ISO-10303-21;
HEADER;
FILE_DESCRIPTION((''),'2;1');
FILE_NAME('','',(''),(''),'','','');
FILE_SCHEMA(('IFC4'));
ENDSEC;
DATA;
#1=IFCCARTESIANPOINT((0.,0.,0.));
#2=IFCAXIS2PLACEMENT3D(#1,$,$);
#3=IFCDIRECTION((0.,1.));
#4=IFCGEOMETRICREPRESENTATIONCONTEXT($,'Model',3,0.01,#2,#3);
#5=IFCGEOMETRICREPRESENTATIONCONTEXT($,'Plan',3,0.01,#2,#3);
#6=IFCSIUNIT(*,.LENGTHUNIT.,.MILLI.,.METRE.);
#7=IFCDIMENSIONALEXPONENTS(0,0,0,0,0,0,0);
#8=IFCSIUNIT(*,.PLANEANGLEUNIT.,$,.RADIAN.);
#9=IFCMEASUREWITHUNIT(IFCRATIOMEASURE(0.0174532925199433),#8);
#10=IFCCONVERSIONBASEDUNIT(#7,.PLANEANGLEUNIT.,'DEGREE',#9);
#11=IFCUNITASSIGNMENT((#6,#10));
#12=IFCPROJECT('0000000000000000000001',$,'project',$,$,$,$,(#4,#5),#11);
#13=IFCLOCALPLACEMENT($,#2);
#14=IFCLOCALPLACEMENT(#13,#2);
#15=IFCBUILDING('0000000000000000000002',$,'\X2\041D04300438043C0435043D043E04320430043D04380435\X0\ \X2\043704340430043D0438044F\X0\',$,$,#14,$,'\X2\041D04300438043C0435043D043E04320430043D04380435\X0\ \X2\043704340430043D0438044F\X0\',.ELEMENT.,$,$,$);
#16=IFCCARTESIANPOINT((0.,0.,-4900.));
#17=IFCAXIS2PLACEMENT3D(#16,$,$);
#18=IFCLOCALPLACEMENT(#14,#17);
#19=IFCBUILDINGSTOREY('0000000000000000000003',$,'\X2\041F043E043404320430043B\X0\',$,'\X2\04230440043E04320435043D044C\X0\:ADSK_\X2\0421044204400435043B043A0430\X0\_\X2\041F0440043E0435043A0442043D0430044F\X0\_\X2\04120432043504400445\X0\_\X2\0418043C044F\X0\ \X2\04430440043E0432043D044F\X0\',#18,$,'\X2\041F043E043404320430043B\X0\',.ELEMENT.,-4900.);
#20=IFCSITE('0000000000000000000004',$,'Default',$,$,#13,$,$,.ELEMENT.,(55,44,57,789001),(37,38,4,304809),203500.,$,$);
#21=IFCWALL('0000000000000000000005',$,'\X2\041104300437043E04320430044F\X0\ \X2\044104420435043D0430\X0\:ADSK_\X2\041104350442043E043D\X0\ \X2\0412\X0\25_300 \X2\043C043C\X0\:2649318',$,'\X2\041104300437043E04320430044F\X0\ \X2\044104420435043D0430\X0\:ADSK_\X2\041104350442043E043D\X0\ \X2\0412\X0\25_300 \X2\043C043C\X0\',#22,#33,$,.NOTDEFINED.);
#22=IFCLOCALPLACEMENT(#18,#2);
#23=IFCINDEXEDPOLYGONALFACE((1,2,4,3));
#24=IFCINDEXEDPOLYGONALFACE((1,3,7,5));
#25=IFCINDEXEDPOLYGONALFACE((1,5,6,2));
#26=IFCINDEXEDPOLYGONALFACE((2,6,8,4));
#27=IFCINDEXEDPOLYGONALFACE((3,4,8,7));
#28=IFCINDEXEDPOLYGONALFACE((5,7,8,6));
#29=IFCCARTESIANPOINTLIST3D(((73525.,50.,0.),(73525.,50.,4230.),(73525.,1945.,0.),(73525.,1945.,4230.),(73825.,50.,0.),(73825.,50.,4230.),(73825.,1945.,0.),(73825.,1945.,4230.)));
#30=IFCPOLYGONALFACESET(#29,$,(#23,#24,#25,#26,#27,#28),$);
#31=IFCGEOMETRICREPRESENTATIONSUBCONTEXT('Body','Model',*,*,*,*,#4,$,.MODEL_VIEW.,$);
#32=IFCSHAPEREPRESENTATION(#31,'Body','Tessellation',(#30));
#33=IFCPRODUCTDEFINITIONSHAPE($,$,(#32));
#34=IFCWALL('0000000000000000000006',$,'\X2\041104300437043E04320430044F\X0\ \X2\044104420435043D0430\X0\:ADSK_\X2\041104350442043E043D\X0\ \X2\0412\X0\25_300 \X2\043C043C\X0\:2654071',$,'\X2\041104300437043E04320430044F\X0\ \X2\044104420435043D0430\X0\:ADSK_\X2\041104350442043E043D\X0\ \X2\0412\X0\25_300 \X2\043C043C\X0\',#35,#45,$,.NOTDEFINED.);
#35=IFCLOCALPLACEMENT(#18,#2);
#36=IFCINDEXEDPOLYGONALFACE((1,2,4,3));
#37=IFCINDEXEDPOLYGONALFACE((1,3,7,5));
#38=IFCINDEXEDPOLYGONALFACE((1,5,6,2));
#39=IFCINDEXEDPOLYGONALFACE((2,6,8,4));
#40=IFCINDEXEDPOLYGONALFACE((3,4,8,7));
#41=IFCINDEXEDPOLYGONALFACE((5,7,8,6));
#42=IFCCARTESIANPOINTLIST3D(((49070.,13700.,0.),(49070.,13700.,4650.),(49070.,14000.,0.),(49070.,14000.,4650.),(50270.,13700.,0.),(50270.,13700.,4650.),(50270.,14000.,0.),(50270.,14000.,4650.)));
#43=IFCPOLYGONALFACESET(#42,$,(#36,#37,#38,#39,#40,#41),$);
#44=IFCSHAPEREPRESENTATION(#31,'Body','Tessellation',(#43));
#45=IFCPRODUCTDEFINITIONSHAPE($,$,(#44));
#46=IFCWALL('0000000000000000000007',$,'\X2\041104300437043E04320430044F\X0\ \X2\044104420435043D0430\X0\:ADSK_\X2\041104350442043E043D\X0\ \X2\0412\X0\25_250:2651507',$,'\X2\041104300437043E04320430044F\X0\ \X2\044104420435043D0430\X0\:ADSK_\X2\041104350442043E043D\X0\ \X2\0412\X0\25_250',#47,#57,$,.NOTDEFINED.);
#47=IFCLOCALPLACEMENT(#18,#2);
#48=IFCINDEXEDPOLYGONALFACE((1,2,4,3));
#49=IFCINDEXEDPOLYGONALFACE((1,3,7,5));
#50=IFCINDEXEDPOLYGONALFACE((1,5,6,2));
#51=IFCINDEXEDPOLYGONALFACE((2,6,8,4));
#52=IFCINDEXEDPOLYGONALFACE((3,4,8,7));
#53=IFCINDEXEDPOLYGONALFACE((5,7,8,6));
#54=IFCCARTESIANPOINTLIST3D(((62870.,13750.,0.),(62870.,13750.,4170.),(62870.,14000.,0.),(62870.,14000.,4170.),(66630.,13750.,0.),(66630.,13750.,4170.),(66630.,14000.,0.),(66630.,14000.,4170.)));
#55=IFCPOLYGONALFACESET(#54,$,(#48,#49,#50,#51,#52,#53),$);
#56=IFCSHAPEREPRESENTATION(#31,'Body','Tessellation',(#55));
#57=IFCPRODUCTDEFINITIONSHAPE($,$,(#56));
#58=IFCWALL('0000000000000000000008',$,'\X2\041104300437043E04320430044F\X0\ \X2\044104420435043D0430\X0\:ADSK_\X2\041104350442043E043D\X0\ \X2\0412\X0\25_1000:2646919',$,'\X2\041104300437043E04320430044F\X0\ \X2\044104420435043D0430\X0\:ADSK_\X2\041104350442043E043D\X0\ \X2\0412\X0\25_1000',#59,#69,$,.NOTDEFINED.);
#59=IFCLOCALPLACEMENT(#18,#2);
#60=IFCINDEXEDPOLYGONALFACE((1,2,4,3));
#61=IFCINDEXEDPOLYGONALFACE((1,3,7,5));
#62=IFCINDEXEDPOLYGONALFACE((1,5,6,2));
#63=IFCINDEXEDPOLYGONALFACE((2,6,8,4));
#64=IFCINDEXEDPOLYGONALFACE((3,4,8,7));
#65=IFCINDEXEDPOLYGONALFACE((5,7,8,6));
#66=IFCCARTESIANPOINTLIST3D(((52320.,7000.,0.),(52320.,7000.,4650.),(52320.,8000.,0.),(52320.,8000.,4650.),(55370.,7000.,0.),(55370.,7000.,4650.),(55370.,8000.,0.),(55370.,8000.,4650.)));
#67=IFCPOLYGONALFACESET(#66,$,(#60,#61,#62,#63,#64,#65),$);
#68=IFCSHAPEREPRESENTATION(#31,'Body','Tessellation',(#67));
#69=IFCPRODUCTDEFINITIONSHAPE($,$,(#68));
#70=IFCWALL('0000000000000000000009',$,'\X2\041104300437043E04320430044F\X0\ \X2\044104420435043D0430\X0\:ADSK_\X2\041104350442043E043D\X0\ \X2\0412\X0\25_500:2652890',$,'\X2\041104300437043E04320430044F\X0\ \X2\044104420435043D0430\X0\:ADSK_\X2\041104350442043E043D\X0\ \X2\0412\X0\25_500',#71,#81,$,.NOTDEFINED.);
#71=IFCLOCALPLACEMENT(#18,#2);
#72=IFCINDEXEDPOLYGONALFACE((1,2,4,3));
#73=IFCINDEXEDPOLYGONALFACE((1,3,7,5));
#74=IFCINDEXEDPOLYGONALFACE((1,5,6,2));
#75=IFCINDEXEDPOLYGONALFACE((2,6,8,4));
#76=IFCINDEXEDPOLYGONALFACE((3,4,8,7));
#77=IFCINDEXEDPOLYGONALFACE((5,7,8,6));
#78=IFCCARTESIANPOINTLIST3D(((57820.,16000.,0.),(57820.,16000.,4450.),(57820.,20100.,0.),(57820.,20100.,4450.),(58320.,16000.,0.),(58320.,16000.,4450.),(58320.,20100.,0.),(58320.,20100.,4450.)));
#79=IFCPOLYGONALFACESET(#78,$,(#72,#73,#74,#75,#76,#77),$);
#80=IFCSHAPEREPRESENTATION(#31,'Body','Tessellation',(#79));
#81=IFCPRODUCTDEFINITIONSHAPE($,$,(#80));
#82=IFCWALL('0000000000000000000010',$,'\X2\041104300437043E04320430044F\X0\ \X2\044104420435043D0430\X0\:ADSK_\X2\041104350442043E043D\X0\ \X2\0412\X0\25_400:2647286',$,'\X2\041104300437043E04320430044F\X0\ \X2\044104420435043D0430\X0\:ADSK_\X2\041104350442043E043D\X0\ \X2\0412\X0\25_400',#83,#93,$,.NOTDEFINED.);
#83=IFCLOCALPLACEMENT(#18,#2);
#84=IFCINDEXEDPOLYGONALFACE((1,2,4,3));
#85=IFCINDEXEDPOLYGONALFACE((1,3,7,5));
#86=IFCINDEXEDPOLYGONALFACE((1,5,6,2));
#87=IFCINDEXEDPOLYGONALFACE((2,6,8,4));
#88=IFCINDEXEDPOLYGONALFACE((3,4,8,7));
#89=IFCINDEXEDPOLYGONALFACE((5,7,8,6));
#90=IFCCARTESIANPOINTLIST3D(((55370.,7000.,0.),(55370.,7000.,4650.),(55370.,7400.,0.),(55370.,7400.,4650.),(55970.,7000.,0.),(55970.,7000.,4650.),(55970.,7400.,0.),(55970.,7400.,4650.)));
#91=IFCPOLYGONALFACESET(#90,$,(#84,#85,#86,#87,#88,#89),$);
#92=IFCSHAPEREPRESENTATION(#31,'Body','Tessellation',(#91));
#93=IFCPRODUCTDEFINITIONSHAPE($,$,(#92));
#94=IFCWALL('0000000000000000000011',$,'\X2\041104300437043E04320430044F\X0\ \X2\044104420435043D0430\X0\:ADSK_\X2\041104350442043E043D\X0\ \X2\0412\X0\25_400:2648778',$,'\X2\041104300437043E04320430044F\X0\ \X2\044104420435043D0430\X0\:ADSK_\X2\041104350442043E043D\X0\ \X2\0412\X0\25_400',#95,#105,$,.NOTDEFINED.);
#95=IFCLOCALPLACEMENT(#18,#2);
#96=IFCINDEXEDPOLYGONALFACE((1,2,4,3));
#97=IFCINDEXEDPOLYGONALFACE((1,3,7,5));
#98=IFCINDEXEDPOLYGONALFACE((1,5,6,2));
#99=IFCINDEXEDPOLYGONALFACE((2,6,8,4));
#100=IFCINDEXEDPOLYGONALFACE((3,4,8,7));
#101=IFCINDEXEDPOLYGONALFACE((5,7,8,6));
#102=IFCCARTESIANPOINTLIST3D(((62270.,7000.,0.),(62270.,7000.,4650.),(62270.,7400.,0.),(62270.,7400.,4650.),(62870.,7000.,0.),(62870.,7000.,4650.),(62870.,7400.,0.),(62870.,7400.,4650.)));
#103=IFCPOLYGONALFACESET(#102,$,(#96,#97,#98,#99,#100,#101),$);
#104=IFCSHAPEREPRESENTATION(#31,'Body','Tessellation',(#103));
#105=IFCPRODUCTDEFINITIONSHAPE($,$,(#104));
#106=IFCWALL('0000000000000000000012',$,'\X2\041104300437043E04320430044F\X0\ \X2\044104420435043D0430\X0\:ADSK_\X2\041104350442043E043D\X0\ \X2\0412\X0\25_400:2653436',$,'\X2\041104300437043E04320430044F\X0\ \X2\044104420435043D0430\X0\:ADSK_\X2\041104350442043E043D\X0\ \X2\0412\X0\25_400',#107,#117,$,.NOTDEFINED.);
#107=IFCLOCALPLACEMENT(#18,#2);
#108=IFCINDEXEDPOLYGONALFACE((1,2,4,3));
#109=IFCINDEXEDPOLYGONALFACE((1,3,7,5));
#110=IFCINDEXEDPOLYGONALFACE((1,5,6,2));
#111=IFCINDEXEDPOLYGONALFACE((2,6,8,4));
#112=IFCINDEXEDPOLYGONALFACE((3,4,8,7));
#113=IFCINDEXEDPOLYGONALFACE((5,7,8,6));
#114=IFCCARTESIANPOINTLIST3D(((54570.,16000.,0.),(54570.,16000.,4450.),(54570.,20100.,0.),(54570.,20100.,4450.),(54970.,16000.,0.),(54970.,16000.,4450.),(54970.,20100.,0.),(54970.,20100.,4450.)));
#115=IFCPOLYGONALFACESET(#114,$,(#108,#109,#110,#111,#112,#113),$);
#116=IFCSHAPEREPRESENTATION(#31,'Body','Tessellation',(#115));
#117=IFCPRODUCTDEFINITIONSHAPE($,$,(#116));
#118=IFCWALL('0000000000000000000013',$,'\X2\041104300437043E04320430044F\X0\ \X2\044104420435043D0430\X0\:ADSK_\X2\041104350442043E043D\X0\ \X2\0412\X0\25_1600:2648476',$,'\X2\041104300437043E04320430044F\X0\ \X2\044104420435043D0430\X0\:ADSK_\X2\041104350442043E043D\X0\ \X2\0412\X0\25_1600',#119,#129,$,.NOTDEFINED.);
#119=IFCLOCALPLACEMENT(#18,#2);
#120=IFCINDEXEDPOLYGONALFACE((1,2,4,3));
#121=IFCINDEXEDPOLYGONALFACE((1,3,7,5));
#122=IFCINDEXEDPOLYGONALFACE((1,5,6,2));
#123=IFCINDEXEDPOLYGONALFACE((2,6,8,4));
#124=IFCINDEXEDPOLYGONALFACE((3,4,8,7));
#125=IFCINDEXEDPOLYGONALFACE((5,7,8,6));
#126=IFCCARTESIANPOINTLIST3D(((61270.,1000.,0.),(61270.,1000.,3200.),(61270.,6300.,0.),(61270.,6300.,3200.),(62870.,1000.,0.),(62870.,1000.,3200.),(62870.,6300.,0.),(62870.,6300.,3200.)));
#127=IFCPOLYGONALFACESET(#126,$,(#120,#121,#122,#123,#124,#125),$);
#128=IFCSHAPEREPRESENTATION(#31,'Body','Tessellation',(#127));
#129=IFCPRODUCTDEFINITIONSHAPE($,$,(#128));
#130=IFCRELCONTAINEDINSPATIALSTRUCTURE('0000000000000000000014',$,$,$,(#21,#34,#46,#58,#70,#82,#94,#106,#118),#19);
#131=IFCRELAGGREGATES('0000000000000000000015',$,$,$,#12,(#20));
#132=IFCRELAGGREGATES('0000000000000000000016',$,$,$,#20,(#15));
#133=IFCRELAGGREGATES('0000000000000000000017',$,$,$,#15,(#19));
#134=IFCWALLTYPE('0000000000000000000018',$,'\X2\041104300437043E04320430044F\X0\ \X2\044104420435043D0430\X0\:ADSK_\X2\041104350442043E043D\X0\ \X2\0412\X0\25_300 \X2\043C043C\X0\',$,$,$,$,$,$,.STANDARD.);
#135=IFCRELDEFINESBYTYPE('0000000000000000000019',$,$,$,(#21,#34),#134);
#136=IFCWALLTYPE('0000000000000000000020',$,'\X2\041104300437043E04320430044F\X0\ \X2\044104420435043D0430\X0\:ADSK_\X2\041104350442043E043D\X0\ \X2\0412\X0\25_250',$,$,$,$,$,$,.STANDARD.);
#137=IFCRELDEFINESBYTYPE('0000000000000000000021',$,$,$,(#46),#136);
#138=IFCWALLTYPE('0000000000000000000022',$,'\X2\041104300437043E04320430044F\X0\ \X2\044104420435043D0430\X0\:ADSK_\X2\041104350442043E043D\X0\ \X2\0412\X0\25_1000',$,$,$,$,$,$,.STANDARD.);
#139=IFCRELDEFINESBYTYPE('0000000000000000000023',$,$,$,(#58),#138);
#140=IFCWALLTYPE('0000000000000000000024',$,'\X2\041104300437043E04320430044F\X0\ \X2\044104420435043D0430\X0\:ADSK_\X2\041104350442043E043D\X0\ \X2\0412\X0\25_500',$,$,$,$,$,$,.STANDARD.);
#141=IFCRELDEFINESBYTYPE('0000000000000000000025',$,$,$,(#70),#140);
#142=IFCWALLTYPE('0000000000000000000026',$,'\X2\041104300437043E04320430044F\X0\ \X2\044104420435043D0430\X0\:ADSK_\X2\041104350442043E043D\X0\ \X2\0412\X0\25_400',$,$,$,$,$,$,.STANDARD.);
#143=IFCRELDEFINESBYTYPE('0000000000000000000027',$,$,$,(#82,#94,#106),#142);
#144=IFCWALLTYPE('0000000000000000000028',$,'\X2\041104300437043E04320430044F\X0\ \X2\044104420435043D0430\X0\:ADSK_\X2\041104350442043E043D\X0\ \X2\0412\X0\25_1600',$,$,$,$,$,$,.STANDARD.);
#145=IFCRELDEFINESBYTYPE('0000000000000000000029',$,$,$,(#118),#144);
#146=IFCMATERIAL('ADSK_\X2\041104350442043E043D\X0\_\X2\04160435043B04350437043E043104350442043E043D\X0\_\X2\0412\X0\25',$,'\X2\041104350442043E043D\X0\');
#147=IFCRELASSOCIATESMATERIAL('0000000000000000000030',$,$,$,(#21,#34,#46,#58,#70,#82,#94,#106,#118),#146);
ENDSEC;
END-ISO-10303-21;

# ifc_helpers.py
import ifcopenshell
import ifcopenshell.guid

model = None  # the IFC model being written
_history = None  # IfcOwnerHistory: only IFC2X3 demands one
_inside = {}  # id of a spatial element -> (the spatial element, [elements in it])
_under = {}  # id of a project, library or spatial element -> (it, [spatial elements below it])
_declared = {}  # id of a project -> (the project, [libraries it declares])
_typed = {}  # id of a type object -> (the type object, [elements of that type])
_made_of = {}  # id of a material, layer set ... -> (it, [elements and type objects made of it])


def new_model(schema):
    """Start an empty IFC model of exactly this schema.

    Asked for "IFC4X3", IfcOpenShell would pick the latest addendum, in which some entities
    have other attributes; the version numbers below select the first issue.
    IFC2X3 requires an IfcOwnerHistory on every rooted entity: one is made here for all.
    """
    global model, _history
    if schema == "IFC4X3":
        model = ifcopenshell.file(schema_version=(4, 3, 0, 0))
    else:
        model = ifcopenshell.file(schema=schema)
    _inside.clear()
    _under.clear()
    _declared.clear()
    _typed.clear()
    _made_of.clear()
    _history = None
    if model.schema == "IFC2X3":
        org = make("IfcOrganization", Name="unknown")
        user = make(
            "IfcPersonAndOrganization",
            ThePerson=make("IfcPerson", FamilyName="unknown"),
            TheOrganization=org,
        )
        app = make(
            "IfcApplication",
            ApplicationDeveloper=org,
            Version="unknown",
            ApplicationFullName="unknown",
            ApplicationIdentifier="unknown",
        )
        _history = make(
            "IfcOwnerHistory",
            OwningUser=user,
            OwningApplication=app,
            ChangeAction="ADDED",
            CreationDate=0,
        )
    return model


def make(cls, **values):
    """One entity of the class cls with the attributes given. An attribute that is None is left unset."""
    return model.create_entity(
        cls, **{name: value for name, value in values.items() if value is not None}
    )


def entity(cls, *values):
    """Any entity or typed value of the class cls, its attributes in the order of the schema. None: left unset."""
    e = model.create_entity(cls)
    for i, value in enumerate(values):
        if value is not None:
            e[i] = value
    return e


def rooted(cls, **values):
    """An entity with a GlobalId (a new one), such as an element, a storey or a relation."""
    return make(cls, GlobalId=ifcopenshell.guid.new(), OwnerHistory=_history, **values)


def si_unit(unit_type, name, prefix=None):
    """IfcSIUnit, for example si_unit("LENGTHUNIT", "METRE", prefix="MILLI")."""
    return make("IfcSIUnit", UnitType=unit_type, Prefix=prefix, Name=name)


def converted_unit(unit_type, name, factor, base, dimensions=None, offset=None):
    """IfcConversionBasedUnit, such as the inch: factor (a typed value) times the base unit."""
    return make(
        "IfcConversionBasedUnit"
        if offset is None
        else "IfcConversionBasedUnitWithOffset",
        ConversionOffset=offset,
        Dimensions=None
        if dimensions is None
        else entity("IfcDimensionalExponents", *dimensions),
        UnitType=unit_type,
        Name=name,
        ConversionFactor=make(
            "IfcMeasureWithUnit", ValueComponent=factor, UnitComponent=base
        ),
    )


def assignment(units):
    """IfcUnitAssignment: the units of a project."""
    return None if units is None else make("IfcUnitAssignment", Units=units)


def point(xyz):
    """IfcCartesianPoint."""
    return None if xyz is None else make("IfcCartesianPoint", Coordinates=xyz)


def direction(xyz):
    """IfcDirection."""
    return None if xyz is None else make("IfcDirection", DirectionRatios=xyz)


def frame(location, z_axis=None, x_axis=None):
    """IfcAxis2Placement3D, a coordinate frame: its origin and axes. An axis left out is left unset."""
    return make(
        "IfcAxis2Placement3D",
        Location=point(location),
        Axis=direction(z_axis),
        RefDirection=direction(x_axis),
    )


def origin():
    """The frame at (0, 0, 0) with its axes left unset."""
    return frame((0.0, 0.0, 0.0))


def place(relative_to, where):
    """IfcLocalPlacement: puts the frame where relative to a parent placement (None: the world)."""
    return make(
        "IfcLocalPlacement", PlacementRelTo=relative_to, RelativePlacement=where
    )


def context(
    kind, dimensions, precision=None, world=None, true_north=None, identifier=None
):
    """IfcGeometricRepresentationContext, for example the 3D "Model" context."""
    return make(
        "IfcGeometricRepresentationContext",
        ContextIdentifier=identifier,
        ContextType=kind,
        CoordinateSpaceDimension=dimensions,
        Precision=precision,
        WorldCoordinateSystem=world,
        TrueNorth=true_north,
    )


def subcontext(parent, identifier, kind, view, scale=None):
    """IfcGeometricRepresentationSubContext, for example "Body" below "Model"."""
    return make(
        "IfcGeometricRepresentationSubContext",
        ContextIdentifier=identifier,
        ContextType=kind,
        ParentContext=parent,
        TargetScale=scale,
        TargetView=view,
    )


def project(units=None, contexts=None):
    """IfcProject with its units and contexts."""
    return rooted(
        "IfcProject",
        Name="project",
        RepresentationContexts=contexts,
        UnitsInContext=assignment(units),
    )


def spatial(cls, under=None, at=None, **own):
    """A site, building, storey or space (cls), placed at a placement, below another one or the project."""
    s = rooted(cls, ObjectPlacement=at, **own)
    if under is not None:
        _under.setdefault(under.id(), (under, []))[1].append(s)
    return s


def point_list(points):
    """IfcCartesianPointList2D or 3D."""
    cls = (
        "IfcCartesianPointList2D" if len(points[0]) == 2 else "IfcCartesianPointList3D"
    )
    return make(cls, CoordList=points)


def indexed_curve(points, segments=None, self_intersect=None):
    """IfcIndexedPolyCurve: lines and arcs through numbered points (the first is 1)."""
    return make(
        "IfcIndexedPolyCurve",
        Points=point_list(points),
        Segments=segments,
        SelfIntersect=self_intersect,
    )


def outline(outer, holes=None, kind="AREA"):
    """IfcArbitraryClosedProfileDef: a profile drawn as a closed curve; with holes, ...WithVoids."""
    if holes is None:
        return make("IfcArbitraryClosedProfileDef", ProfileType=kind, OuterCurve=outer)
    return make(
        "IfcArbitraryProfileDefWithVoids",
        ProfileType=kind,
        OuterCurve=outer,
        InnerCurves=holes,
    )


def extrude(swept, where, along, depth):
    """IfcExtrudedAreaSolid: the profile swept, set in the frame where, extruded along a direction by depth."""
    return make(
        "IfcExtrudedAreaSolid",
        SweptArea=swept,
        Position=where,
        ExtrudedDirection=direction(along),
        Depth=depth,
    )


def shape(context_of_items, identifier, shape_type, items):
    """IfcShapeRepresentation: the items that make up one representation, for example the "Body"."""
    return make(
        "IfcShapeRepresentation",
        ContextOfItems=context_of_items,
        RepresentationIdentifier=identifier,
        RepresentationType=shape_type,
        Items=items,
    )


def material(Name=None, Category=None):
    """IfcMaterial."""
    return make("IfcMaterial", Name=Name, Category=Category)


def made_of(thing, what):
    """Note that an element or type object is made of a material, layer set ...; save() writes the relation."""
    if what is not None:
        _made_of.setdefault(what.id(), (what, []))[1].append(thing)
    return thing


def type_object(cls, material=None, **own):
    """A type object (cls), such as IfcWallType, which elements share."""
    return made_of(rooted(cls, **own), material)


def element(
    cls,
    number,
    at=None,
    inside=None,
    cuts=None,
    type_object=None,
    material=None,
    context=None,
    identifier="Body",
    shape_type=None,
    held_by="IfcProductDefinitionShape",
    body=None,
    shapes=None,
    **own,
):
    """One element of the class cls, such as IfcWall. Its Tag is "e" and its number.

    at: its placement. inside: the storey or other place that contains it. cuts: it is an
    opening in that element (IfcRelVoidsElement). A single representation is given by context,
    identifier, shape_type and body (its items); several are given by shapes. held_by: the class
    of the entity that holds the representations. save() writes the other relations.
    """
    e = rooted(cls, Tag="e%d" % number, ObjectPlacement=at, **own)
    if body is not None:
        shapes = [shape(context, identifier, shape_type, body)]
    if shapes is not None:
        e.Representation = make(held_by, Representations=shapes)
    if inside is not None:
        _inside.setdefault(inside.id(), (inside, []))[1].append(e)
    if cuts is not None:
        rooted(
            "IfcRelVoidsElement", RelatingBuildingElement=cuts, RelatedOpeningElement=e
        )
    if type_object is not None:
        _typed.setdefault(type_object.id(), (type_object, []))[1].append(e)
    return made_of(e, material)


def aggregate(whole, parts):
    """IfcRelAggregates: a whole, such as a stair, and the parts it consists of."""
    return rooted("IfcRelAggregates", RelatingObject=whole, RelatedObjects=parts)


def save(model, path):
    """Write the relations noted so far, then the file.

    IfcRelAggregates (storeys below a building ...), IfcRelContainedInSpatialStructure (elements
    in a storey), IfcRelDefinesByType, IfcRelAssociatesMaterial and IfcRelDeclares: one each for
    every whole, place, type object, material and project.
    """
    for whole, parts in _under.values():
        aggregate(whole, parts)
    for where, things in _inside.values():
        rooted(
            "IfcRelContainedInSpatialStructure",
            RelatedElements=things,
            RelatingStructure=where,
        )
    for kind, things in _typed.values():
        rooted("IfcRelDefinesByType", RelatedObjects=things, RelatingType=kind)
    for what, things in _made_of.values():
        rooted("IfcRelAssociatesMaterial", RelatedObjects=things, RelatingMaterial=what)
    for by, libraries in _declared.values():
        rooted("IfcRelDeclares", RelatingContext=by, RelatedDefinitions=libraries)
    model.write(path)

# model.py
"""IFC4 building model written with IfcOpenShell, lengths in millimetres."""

from ifc_helpers import new_model, entity, si_unit, converted_unit, direction, frame, origin, place, context, subcontext, project, spatial, indexed_curve, outline, extrude, material, type_object, element, save


model = new_model("IFC4")

# Units and contexts
model_context = context("Model", 3, precision=0.01, world=origin(), true_north=direction((0.0, 1.0)))
plan_context = context("Plan", 3, precision=0.01, world=origin(), true_north=direction((0.0, 1.0)))
body_context = subcontext(model_context, "Body", "Model", "MODEL_VIEW")
ifc_project = project(units=[si_unit("LENGTHUNIT", "METRE", prefix="MILLI"), converted_unit("PLANEANGLEUNIT", "DEGREE", entity("IfcRatioMeasure", 0.0174532925199433), si_unit("PLANEANGLEUNIT", "RADIAN"), dimensions=[0, 0, 0, 0, 0, 0, 0])], contexts=[model_context, plan_context])

# Site, building, storey
site_placement = place(None, origin())
site = spatial("IfcSite", under=ifc_project, at=site_placement, Name="Default", CompositionType="ELEMENT", RefLatitude=(55, 44, 57, 789001), RefLongitude=(37, 38, 4, 304809), RefElevation=203500.0)
building_placement = place(site_placement, origin())
building = spatial("IfcBuilding", under=site, at=building_placement, Name="Наименование здания", LongName="Наименование здания", CompositionType="ELEMENT")
storey_placement = place(building_placement, frame((0.0, 0.0, -4900.0)))
storey = spatial("IfcBuildingStorey", under=building, at=storey_placement, Name="Подвал", ObjectType="Уровень:ADSK_Стрелка_Проектная_Вверх_Имя уровня", LongName="Подвал", CompositionType="ELEMENT", Elevation=-4900.0)

# Shared definitions
ifc_material = material(Name="ADSK_Бетон_Железобетон_В25", Category="Бетон")

# Walls
wall_type_1 = type_object("IfcWallType", Name="Базовая стена:ADSK_Бетон В25_300 мм", PredefinedType="STANDARD")
wall_1_placement = place(storey_placement, frame((73675.0, 1945.0, 0.0), z_axis=(0.0, 0.0, 1.0), x_axis=(0.0, -1.0, 0.0)))
element("IfcWall", 1, at=wall_1_placement, inside=storey, type_object=wall_type_1, material=ifc_material, Name="Базовая стена:ADSK_Бетон В25_300 мм:2649318", ObjectType="Базовая стена:ADSK_Бетон В25_300 мм", PredefinedType="NOTDEFINED", context=body_context, shape_type="SweptSolid", body=[
    extrude(outline(indexed_curve([(1895.0, 150.0), (0.0, 150.0), (0.0, -150.0), (1895.0, -150.0), (1895.0, 150.0)], self_intersect=False)), origin(), (0.0, 0.0, 1.0), 4230.0),
])
wall_2_placement = place(storey_placement, frame((49070.0, 13850.0, 0.0)))
element("IfcWall", 2, at=wall_2_placement, inside=storey, type_object=wall_type_1, material=ifc_material, Name="Базовая стена:ADSK_Бетон В25_300 мм:2654071", ObjectType="Базовая стена:ADSK_Бетон В25_300 мм", PredefinedType="NOTDEFINED", context=body_context, shape_type="SweptSolid", body=[
    extrude(outline(indexed_curve([(1200.0, 150.0), (0.0, 150.0), (0.0, -150.0), (1200.0, -150.0), (1200.0, 150.0)], self_intersect=False)), origin(), (0.0, 0.0, 1.0), 4650.0),
])
wall_type_2 = type_object("IfcWallType", Name="Базовая стена:ADSK_Бетон В25_250", PredefinedType="STANDARD")
wall_3_placement = place(storey_placement, frame((62870.0, 13875.0, 0.0)))
element("IfcWall", 3, at=wall_3_placement, inside=storey, type_object=wall_type_2, material=ifc_material, Name="Базовая стена:ADSK_Бетон В25_250:2651507", ObjectType="Базовая стена:ADSK_Бетон В25_250", PredefinedType="NOTDEFINED", context=body_context, shape_type="SweptSolid", body=[
    extrude(outline(indexed_curve([(3760.0, 125.0), (0.0, 125.0), (0.0, -125.0), (3760.0, -125.0), (3760.0, 125.0)], self_intersect=False)), origin(), (0.0, 0.0, 1.0), 4170.0),
])
wall_type_3 = type_object("IfcWallType", Name="Базовая стена:ADSK_Бетон В25_1000", PredefinedType="STANDARD")
wall_4_placement = place(storey_placement, frame((52320.0, 7500.0, 0.0)))
element("IfcWall", 4, at=wall_4_placement, inside=storey, type_object=wall_type_3, material=ifc_material, Name="Базовая стена:ADSK_Бетон В25_1000:2646919", ObjectType="Базовая стена:ADSK_Бетон В25_1000", PredefinedType="NOTDEFINED", context=body_context, shape_type="SweptSolid", body=[
    extrude(outline(indexed_curve([(3050.0, 500.0), (0.0, 500.0), (0.0, -500.0), (3050.0, -500.0), (3050.0, 500.0)], self_intersect=False)), origin(), (0.0, 0.0, 1.0), 4650.0),
])
wall_type_4 = type_object("IfcWallType", Name="Базовая стена:ADSK_Бетон В25_500", PredefinedType="STANDARD")
wall_5_placement = place(storey_placement, frame((58070.0, 20100.0, 0.0), z_axis=(0.0, 0.0, 1.0), x_axis=(0.0, -1.0, 0.0)))
element("IfcWall", 5, at=wall_5_placement, inside=storey, type_object=wall_type_4, material=ifc_material, Name="Базовая стена:ADSK_Бетон В25_500:2652890", ObjectType="Базовая стена:ADSK_Бетон В25_500", PredefinedType="NOTDEFINED", context=body_context, shape_type="SweptSolid", body=[
    extrude(outline(indexed_curve([(4100.0, 250.0), (0.0, 250.0), (0.0, -250.0), (4100.0, -250.0), (4100.0, 250.0)], self_intersect=False)), origin(), (0.0, 0.0, 1.0), 4450.0),
])
wall_type_5 = type_object("IfcWallType", Name="Базовая стена:ADSK_Бетон В25_400", PredefinedType="STANDARD")
wall_6_placement = place(storey_placement, frame((55370.0, 7200.0, 0.0)))
element("IfcWall", 6, at=wall_6_placement, inside=storey, type_object=wall_type_5, material=ifc_material, Name="Базовая стена:ADSK_Бетон В25_400:2647286", ObjectType="Базовая стена:ADSK_Бетон В25_400", PredefinedType="NOTDEFINED", context=body_context, shape_type="SweptSolid", body=[
    extrude(outline(indexed_curve([(600.0, 200.0), (0.0, 200.0), (0.0, -200.0), (600.0, -200.0), (600.0, 200.0)], self_intersect=False)), origin(), (0.0, 0.0, 1.0), 4650.0),
])
wall_7_placement = place(storey_placement, frame((62270.0, 7200.0, 0.0)))
element("IfcWall", 7, at=wall_7_placement, inside=storey, type_object=wall_type_5, material=ifc_material, Name="Базовая стена:ADSK_Бетон В25_400:2648778", ObjectType="Базовая стена:ADSK_Бетон В25_400", PredefinedType="NOTDEFINED", context=body_context, shape_type="SweptSolid", body=[
    extrude(outline(indexed_curve([(600.0, 200.0), (0.0, 200.0), (0.0, -200.0), (600.0, -200.0), (600.0, 200.0)], self_intersect=False)), origin(), (0.0, 0.0, 1.0), 4650.0),
])
wall_8_placement = place(storey_placement, frame((54770.0, 20100.0, 0.0), z_axis=(0.0, 0.0, 1.0), x_axis=(0.0, -1.0, 0.0)))
element("IfcWall", 8, at=wall_8_placement, inside=storey, type_object=wall_type_5, material=ifc_material, Name="Базовая стена:ADSK_Бетон В25_400:2653436", ObjectType="Базовая стена:ADSK_Бетон В25_400", PredefinedType="NOTDEFINED", context=body_context, shape_type="SweptSolid", body=[
    extrude(outline(indexed_curve([(4100.0, 200.0), (0.0, 200.0), (0.0, -200.0), (4100.0, -200.0), (4100.0, 200.0)], self_intersect=False)), origin(), (0.0, 0.0, 1.0), 4450.0),
])
wall_type_6 = type_object("IfcWallType", Name="Базовая стена:ADSK_Бетон В25_1600", PredefinedType="STANDARD")
wall_9_placement = place(storey_placement, frame((62070.0, 1000.0, 0.0), z_axis=(0.0, 0.0, 1.0), x_axis=(0.0, 1.0, 0.0)))
element("IfcWall", 9, at=wall_9_placement, inside=storey, type_object=wall_type_6, material=ifc_material, Name="Базовая стена:ADSK_Бетон В25_1600:2648476", ObjectType="Базовая стена:ADSK_Бетон В25_1600", PredefinedType="NOTDEFINED", context=body_context, shape_type="SweptSolid", body=[
    extrude(outline(indexed_curve([(-800.0, -2650.0), (800.0, -2650.0), (800.0, 2650.0), (-800.0, 2650.0), (-800.0, -2650.0)], self_intersect=False)), frame((2650.0, 0.0, 0.0), z_axis=(0.0, 0.0, 1.0), x_axis=(0.0, 1.0, 0.0)), (0.0, 0.0, 1.0), 3200.0),
])

save(model, "model.ifc")
